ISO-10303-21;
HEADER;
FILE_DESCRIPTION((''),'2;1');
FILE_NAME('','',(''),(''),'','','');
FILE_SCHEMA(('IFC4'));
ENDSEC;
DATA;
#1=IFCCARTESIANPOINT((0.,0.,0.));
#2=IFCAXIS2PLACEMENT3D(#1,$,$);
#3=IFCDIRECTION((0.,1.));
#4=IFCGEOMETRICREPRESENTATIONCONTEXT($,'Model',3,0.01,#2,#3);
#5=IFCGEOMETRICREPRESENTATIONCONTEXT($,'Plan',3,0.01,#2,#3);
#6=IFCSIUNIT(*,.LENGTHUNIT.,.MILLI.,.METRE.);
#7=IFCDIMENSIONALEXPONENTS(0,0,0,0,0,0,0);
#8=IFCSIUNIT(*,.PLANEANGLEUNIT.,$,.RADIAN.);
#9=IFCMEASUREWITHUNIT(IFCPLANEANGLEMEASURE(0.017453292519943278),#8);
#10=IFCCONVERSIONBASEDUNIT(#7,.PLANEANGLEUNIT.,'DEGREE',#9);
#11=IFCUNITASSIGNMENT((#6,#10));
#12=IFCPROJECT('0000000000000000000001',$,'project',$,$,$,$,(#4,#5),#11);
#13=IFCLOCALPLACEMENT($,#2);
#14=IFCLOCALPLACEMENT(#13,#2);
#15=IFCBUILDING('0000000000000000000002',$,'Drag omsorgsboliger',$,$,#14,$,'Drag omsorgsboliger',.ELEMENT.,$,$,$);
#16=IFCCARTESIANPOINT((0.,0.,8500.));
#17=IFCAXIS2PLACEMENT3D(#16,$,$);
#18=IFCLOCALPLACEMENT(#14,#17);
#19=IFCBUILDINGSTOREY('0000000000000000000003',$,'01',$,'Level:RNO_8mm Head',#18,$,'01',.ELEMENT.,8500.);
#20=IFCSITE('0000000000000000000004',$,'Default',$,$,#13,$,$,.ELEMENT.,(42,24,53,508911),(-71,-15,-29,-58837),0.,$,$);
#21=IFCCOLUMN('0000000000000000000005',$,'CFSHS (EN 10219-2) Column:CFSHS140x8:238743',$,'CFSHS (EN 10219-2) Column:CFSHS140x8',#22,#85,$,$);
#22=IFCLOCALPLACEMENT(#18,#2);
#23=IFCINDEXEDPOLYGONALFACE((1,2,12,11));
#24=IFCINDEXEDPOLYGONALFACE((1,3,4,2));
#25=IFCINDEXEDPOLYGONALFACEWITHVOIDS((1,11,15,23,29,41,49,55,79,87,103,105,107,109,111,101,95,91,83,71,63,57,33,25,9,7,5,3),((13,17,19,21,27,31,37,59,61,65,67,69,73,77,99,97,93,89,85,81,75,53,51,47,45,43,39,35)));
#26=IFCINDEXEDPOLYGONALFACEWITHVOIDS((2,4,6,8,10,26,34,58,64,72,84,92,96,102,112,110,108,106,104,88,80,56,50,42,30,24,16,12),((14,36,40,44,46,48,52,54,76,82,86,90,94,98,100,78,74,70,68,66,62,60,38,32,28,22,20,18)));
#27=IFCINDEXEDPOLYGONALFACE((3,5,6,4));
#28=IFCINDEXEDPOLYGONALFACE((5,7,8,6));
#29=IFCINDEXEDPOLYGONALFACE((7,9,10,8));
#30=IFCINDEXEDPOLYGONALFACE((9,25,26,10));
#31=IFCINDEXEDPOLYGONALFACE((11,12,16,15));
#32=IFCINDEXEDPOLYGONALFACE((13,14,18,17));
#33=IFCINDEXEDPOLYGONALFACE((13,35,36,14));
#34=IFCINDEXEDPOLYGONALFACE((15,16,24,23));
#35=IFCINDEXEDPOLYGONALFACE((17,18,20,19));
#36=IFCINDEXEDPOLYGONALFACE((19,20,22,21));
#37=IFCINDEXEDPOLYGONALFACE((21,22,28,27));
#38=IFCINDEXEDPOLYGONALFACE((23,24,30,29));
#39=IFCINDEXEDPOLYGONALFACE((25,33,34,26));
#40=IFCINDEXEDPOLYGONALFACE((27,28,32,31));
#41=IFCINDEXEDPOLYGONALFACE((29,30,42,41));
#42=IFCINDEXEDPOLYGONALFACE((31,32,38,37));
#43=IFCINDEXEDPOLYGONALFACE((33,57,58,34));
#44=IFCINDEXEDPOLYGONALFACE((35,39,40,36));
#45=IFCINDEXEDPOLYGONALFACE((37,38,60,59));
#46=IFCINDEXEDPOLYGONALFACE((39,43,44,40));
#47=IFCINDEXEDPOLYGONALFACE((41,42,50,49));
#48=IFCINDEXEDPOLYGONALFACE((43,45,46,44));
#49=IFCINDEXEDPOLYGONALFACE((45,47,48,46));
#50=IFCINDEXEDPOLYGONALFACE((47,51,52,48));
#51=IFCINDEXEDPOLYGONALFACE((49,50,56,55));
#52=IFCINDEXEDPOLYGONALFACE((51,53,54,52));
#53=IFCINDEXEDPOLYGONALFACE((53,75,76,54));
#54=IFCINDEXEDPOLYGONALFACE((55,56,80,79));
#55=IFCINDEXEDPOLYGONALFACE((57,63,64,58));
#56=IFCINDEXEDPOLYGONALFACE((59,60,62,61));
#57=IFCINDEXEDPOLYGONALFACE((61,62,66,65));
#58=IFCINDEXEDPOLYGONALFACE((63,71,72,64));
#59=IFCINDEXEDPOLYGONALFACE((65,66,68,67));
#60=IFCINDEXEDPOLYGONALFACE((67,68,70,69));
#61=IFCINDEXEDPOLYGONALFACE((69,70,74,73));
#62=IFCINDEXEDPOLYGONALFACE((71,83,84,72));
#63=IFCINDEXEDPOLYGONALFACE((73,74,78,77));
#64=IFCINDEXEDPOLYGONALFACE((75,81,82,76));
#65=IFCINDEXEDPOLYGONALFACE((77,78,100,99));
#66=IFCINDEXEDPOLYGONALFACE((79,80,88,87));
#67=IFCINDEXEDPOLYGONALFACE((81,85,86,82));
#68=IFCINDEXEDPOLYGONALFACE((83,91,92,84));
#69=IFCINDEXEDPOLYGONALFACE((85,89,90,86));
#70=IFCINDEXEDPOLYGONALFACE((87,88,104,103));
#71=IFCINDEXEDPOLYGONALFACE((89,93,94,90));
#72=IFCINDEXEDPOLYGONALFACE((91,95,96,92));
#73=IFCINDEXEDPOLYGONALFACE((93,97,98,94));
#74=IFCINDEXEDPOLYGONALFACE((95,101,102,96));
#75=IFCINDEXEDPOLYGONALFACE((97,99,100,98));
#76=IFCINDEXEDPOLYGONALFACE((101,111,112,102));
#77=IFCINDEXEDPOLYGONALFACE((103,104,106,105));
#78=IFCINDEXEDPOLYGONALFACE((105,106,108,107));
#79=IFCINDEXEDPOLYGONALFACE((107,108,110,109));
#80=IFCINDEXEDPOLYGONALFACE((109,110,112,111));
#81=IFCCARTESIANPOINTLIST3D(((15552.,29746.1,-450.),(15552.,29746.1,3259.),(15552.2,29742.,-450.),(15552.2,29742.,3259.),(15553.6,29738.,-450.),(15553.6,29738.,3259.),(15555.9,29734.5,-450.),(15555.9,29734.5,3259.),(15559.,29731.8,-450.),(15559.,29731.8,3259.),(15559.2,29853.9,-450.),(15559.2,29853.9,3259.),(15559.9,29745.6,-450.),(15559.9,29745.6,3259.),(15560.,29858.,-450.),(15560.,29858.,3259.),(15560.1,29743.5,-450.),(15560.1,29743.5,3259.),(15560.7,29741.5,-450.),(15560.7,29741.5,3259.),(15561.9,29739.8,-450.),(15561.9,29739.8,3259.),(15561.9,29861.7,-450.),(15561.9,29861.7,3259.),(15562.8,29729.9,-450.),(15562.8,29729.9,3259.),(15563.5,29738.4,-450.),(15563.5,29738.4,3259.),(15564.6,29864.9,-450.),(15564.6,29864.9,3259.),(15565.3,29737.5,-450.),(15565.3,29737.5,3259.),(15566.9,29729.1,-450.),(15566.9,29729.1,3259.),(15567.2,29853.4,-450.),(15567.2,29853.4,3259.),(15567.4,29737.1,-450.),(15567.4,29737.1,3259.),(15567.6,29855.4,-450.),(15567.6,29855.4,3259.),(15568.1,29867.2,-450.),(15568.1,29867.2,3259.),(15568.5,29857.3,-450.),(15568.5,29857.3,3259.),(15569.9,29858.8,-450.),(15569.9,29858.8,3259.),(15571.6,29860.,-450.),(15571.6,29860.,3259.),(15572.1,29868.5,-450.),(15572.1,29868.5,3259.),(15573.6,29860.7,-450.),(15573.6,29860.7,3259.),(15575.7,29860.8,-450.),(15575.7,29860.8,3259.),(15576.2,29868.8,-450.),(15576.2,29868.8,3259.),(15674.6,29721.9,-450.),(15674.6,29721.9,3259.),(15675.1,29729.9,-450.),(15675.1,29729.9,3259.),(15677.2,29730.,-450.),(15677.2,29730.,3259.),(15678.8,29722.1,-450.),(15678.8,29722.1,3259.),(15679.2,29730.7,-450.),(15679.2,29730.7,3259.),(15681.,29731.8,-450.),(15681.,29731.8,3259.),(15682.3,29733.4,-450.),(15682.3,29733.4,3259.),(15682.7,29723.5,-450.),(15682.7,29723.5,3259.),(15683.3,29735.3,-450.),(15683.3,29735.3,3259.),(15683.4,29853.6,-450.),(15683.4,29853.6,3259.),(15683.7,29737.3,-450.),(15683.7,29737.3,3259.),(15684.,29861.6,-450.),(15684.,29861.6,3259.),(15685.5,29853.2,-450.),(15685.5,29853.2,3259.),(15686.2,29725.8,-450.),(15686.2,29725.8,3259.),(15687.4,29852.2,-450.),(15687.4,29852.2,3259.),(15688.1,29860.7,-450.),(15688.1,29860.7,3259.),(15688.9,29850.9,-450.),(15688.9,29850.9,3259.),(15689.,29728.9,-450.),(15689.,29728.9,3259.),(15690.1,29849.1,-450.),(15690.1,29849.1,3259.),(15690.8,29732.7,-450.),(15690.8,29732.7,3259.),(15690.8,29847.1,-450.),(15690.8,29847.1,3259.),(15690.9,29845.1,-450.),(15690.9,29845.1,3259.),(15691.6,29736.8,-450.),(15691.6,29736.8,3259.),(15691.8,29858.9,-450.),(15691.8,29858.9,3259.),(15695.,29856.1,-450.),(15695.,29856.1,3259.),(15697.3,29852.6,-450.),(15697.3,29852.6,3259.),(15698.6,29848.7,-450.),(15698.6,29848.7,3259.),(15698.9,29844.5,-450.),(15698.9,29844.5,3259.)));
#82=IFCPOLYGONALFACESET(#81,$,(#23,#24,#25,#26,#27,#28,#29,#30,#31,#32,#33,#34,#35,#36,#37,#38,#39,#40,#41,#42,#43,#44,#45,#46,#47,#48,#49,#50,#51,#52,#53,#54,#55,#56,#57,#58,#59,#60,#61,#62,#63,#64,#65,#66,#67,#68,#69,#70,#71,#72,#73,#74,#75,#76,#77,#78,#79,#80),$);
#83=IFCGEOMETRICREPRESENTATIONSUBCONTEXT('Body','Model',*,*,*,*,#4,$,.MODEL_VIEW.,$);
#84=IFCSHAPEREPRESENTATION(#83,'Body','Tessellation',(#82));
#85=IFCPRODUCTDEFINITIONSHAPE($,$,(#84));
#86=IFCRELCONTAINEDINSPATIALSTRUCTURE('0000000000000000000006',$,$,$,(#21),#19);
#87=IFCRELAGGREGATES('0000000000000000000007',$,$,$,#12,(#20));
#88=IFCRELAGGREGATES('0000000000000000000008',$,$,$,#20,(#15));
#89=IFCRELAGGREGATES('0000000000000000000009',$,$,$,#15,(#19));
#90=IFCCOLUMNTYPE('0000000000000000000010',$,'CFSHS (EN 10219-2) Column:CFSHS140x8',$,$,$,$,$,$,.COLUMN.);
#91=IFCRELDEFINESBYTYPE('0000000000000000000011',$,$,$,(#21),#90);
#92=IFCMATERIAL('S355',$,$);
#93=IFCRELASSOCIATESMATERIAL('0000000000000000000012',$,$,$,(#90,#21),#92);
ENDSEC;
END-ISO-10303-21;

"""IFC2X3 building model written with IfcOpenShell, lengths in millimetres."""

from ifc_helpers import new_model, entity, si_unit, converted_unit, direction, frame, frame_2d, origin, place, context, subcontext, project, spatial, polyline, circle_curve, parameter, trimmed, segment, composite_curve, outline, extrude, source, transform, mapped, material, type_object, type_shapes, element, save


model = new_model("IFC2X3")

# Units and contexts
model_context = context("Model", 3, precision=0.01, world=origin(), true_north=direction((0.0, 1.0)))
plan_context = context("Plan", 3, precision=0.01, world=origin(), true_north=direction((0.0, 1.0)))
body_context = subcontext(model_context, "Body", "Model", "MODEL_VIEW")
ifc_project = project(units=[si_unit("LENGTHUNIT", "METRE", prefix="MILLI"), converted_unit("PLANEANGLEUNIT", "DEGREE", entity("IfcPlaneAngleMeasure", 0.017453292519943278), si_unit("PLANEANGLEUNIT", "RADIAN"), dimensions=[0, 0, 0, 0, 0, 0, 0])], contexts=[model_context, plan_context])

# Site, building, storey
site_placement = place(None, origin())
site = spatial("IfcSite", under=ifc_project, at=site_placement, Name="Default", CompositionType="ELEMENT", RefLatitude=(42, 24, 53, 508911), RefLongitude=(-71, -15, -29, -58837), RefElevation=0.0)
building_placement = place(site_placement, origin())
building = spatial("IfcBuilding", under=site, at=building_placement, Name="Drag omsorgsboliger", LongName="Drag omsorgsboliger", CompositionType="ELEMENT")
storey_placement = place(building_placement, frame((0.0, 0.0, 8500.0)))
storey = spatial("IfcBuildingStorey", under=building, at=storey_placement, Name="01", ObjectType="Level:RNO_8mm Head", LongName="01", CompositionType="ELEMENT", Elevation=8500.0)

# Column
ifc_material = material(Name="S355")
column_type_1 = type_object("IfcColumnType", Name="CFSHS (EN 10219-2) Column:CFSHS140x8", PredefinedType="COLUMN", material=ifc_material)
shared_shape_1 = source(origin(), body_context, "Body", "SweptSolid", [
    extrude(outline(composite_curve([segment(polyline([(-54.0, -70.0), (54.0, -70.0)]), True, "CONTINUOUS"), segment(trimmed(circle_curve(frame_2d((54.0, -54.0), x_axis=(-1.0, 0.0)), 16.0), [parameter(90.0)], [parameter(180.0)], True, "PARAMETER"), True, "CONTINUOUS"), segment(polyline([(70.0, -54.0), (70.0, 54.0)]), True, "CONTINUOUS"), segment(trimmed(circle_curve(frame_2d((54.0, 54.0), x_axis=(-1.0, 0.0)), 16.0), [parameter(180.0)], [parameter(270.0)], True, "PARAMETER"), True, "CONTINUOUS"), segment(polyline([(54.0, 70.0), (-54.0, 70.0)]), True, "CONTINUOUS"), segment(trimmed(circle_curve(frame_2d((-54.0, 54.0), x_axis=(-1.0, 0.0)), 16.0), [parameter(270.0)], [parameter(360.0)], True, "PARAMETER"), True, "CONTINUOUS"), segment(polyline([(-70.0, 54.0), (-70.0, -54.0)]), True, "CONTINUOUS"), segment(trimmed(circle_curve(frame_2d((-54.0, -54.0), x_axis=(-1.0, 0.0)), 16.0), [parameter(360.0)], [parameter(90.0)], True, "PARAMETER"), True, "CONTINUOUS")], self_intersect=False), holes=[composite_curve([segment(trimmed(circle_curve(frame_2d((-54.0, -54.0), x_axis=(-1.0, 0.0)), 8.0), [parameter(360.0)], [parameter(90.0)], True, "PARAMETER"), False, "CONTINUOUS"), segment(polyline([(-62.0, -54.0), (-62.0, 54.0)]), True, "CONTINUOUS"), segment(trimmed(circle_curve(frame_2d((-54.0, 54.0), x_axis=(-1.0, 0.0)), 8.0), [parameter(270.0)], [parameter(360.0)], True, "PARAMETER"), False, "CONTINUOUS"), segment(polyline([(-54.0, 62.0), (54.0, 62.0)]), True, "CONTINUOUS"), segment(trimmed(circle_curve(frame_2d((54.0, 54.0), x_axis=(-1.0, 0.0)), 8.0), [parameter(180.0)], [parameter(270.0)], True, "PARAMETER"), False, "CONTINUOUS"), segment(polyline([(62.0, 54.0), (62.0, -54.0)]), True, "CONTINUOUS"), segment(trimmed(circle_curve(frame_2d((54.0, -54.0), x_axis=(-1.0, 0.0)), 8.0), [parameter(90.0)], [parameter(180.0)], True, "PARAMETER"), False, "CONTINUOUS"), segment(polyline([(54.0, -62.0), (-54.0, -62.0)]), True, "CONTINUOUS")], self_intersect=False)]), frame((15625.4, 29795.3, 8050.0), z_axis=(0.0, 0.0, 1.0), x_axis=(-0.997758, 0.066923, 0.0)), (0.0, 0.0, 1.0), 3709.0),
])
type_shapes(column_type_1, [shared_shape_1])
column_1_placement = place(storey_placement, frame((0.0, 0.0, -8500.0)))
element("IfcColumn", 1, at=column_1_placement, inside=storey, type_object=column_type_1, material=ifc_material, Name="CFSHS (EN 10219-2) Column:CFSHS140x8:238743", ObjectType="CFSHS (EN 10219-2) Column:CFSHS140x8", context=body_context, shape_type="MappedRepresentation", body=[
    mapped(shared_shape_1, transform((0.0, 0.0, 0.0), scale=1.0)),
])

save(model, "model.ifc")
